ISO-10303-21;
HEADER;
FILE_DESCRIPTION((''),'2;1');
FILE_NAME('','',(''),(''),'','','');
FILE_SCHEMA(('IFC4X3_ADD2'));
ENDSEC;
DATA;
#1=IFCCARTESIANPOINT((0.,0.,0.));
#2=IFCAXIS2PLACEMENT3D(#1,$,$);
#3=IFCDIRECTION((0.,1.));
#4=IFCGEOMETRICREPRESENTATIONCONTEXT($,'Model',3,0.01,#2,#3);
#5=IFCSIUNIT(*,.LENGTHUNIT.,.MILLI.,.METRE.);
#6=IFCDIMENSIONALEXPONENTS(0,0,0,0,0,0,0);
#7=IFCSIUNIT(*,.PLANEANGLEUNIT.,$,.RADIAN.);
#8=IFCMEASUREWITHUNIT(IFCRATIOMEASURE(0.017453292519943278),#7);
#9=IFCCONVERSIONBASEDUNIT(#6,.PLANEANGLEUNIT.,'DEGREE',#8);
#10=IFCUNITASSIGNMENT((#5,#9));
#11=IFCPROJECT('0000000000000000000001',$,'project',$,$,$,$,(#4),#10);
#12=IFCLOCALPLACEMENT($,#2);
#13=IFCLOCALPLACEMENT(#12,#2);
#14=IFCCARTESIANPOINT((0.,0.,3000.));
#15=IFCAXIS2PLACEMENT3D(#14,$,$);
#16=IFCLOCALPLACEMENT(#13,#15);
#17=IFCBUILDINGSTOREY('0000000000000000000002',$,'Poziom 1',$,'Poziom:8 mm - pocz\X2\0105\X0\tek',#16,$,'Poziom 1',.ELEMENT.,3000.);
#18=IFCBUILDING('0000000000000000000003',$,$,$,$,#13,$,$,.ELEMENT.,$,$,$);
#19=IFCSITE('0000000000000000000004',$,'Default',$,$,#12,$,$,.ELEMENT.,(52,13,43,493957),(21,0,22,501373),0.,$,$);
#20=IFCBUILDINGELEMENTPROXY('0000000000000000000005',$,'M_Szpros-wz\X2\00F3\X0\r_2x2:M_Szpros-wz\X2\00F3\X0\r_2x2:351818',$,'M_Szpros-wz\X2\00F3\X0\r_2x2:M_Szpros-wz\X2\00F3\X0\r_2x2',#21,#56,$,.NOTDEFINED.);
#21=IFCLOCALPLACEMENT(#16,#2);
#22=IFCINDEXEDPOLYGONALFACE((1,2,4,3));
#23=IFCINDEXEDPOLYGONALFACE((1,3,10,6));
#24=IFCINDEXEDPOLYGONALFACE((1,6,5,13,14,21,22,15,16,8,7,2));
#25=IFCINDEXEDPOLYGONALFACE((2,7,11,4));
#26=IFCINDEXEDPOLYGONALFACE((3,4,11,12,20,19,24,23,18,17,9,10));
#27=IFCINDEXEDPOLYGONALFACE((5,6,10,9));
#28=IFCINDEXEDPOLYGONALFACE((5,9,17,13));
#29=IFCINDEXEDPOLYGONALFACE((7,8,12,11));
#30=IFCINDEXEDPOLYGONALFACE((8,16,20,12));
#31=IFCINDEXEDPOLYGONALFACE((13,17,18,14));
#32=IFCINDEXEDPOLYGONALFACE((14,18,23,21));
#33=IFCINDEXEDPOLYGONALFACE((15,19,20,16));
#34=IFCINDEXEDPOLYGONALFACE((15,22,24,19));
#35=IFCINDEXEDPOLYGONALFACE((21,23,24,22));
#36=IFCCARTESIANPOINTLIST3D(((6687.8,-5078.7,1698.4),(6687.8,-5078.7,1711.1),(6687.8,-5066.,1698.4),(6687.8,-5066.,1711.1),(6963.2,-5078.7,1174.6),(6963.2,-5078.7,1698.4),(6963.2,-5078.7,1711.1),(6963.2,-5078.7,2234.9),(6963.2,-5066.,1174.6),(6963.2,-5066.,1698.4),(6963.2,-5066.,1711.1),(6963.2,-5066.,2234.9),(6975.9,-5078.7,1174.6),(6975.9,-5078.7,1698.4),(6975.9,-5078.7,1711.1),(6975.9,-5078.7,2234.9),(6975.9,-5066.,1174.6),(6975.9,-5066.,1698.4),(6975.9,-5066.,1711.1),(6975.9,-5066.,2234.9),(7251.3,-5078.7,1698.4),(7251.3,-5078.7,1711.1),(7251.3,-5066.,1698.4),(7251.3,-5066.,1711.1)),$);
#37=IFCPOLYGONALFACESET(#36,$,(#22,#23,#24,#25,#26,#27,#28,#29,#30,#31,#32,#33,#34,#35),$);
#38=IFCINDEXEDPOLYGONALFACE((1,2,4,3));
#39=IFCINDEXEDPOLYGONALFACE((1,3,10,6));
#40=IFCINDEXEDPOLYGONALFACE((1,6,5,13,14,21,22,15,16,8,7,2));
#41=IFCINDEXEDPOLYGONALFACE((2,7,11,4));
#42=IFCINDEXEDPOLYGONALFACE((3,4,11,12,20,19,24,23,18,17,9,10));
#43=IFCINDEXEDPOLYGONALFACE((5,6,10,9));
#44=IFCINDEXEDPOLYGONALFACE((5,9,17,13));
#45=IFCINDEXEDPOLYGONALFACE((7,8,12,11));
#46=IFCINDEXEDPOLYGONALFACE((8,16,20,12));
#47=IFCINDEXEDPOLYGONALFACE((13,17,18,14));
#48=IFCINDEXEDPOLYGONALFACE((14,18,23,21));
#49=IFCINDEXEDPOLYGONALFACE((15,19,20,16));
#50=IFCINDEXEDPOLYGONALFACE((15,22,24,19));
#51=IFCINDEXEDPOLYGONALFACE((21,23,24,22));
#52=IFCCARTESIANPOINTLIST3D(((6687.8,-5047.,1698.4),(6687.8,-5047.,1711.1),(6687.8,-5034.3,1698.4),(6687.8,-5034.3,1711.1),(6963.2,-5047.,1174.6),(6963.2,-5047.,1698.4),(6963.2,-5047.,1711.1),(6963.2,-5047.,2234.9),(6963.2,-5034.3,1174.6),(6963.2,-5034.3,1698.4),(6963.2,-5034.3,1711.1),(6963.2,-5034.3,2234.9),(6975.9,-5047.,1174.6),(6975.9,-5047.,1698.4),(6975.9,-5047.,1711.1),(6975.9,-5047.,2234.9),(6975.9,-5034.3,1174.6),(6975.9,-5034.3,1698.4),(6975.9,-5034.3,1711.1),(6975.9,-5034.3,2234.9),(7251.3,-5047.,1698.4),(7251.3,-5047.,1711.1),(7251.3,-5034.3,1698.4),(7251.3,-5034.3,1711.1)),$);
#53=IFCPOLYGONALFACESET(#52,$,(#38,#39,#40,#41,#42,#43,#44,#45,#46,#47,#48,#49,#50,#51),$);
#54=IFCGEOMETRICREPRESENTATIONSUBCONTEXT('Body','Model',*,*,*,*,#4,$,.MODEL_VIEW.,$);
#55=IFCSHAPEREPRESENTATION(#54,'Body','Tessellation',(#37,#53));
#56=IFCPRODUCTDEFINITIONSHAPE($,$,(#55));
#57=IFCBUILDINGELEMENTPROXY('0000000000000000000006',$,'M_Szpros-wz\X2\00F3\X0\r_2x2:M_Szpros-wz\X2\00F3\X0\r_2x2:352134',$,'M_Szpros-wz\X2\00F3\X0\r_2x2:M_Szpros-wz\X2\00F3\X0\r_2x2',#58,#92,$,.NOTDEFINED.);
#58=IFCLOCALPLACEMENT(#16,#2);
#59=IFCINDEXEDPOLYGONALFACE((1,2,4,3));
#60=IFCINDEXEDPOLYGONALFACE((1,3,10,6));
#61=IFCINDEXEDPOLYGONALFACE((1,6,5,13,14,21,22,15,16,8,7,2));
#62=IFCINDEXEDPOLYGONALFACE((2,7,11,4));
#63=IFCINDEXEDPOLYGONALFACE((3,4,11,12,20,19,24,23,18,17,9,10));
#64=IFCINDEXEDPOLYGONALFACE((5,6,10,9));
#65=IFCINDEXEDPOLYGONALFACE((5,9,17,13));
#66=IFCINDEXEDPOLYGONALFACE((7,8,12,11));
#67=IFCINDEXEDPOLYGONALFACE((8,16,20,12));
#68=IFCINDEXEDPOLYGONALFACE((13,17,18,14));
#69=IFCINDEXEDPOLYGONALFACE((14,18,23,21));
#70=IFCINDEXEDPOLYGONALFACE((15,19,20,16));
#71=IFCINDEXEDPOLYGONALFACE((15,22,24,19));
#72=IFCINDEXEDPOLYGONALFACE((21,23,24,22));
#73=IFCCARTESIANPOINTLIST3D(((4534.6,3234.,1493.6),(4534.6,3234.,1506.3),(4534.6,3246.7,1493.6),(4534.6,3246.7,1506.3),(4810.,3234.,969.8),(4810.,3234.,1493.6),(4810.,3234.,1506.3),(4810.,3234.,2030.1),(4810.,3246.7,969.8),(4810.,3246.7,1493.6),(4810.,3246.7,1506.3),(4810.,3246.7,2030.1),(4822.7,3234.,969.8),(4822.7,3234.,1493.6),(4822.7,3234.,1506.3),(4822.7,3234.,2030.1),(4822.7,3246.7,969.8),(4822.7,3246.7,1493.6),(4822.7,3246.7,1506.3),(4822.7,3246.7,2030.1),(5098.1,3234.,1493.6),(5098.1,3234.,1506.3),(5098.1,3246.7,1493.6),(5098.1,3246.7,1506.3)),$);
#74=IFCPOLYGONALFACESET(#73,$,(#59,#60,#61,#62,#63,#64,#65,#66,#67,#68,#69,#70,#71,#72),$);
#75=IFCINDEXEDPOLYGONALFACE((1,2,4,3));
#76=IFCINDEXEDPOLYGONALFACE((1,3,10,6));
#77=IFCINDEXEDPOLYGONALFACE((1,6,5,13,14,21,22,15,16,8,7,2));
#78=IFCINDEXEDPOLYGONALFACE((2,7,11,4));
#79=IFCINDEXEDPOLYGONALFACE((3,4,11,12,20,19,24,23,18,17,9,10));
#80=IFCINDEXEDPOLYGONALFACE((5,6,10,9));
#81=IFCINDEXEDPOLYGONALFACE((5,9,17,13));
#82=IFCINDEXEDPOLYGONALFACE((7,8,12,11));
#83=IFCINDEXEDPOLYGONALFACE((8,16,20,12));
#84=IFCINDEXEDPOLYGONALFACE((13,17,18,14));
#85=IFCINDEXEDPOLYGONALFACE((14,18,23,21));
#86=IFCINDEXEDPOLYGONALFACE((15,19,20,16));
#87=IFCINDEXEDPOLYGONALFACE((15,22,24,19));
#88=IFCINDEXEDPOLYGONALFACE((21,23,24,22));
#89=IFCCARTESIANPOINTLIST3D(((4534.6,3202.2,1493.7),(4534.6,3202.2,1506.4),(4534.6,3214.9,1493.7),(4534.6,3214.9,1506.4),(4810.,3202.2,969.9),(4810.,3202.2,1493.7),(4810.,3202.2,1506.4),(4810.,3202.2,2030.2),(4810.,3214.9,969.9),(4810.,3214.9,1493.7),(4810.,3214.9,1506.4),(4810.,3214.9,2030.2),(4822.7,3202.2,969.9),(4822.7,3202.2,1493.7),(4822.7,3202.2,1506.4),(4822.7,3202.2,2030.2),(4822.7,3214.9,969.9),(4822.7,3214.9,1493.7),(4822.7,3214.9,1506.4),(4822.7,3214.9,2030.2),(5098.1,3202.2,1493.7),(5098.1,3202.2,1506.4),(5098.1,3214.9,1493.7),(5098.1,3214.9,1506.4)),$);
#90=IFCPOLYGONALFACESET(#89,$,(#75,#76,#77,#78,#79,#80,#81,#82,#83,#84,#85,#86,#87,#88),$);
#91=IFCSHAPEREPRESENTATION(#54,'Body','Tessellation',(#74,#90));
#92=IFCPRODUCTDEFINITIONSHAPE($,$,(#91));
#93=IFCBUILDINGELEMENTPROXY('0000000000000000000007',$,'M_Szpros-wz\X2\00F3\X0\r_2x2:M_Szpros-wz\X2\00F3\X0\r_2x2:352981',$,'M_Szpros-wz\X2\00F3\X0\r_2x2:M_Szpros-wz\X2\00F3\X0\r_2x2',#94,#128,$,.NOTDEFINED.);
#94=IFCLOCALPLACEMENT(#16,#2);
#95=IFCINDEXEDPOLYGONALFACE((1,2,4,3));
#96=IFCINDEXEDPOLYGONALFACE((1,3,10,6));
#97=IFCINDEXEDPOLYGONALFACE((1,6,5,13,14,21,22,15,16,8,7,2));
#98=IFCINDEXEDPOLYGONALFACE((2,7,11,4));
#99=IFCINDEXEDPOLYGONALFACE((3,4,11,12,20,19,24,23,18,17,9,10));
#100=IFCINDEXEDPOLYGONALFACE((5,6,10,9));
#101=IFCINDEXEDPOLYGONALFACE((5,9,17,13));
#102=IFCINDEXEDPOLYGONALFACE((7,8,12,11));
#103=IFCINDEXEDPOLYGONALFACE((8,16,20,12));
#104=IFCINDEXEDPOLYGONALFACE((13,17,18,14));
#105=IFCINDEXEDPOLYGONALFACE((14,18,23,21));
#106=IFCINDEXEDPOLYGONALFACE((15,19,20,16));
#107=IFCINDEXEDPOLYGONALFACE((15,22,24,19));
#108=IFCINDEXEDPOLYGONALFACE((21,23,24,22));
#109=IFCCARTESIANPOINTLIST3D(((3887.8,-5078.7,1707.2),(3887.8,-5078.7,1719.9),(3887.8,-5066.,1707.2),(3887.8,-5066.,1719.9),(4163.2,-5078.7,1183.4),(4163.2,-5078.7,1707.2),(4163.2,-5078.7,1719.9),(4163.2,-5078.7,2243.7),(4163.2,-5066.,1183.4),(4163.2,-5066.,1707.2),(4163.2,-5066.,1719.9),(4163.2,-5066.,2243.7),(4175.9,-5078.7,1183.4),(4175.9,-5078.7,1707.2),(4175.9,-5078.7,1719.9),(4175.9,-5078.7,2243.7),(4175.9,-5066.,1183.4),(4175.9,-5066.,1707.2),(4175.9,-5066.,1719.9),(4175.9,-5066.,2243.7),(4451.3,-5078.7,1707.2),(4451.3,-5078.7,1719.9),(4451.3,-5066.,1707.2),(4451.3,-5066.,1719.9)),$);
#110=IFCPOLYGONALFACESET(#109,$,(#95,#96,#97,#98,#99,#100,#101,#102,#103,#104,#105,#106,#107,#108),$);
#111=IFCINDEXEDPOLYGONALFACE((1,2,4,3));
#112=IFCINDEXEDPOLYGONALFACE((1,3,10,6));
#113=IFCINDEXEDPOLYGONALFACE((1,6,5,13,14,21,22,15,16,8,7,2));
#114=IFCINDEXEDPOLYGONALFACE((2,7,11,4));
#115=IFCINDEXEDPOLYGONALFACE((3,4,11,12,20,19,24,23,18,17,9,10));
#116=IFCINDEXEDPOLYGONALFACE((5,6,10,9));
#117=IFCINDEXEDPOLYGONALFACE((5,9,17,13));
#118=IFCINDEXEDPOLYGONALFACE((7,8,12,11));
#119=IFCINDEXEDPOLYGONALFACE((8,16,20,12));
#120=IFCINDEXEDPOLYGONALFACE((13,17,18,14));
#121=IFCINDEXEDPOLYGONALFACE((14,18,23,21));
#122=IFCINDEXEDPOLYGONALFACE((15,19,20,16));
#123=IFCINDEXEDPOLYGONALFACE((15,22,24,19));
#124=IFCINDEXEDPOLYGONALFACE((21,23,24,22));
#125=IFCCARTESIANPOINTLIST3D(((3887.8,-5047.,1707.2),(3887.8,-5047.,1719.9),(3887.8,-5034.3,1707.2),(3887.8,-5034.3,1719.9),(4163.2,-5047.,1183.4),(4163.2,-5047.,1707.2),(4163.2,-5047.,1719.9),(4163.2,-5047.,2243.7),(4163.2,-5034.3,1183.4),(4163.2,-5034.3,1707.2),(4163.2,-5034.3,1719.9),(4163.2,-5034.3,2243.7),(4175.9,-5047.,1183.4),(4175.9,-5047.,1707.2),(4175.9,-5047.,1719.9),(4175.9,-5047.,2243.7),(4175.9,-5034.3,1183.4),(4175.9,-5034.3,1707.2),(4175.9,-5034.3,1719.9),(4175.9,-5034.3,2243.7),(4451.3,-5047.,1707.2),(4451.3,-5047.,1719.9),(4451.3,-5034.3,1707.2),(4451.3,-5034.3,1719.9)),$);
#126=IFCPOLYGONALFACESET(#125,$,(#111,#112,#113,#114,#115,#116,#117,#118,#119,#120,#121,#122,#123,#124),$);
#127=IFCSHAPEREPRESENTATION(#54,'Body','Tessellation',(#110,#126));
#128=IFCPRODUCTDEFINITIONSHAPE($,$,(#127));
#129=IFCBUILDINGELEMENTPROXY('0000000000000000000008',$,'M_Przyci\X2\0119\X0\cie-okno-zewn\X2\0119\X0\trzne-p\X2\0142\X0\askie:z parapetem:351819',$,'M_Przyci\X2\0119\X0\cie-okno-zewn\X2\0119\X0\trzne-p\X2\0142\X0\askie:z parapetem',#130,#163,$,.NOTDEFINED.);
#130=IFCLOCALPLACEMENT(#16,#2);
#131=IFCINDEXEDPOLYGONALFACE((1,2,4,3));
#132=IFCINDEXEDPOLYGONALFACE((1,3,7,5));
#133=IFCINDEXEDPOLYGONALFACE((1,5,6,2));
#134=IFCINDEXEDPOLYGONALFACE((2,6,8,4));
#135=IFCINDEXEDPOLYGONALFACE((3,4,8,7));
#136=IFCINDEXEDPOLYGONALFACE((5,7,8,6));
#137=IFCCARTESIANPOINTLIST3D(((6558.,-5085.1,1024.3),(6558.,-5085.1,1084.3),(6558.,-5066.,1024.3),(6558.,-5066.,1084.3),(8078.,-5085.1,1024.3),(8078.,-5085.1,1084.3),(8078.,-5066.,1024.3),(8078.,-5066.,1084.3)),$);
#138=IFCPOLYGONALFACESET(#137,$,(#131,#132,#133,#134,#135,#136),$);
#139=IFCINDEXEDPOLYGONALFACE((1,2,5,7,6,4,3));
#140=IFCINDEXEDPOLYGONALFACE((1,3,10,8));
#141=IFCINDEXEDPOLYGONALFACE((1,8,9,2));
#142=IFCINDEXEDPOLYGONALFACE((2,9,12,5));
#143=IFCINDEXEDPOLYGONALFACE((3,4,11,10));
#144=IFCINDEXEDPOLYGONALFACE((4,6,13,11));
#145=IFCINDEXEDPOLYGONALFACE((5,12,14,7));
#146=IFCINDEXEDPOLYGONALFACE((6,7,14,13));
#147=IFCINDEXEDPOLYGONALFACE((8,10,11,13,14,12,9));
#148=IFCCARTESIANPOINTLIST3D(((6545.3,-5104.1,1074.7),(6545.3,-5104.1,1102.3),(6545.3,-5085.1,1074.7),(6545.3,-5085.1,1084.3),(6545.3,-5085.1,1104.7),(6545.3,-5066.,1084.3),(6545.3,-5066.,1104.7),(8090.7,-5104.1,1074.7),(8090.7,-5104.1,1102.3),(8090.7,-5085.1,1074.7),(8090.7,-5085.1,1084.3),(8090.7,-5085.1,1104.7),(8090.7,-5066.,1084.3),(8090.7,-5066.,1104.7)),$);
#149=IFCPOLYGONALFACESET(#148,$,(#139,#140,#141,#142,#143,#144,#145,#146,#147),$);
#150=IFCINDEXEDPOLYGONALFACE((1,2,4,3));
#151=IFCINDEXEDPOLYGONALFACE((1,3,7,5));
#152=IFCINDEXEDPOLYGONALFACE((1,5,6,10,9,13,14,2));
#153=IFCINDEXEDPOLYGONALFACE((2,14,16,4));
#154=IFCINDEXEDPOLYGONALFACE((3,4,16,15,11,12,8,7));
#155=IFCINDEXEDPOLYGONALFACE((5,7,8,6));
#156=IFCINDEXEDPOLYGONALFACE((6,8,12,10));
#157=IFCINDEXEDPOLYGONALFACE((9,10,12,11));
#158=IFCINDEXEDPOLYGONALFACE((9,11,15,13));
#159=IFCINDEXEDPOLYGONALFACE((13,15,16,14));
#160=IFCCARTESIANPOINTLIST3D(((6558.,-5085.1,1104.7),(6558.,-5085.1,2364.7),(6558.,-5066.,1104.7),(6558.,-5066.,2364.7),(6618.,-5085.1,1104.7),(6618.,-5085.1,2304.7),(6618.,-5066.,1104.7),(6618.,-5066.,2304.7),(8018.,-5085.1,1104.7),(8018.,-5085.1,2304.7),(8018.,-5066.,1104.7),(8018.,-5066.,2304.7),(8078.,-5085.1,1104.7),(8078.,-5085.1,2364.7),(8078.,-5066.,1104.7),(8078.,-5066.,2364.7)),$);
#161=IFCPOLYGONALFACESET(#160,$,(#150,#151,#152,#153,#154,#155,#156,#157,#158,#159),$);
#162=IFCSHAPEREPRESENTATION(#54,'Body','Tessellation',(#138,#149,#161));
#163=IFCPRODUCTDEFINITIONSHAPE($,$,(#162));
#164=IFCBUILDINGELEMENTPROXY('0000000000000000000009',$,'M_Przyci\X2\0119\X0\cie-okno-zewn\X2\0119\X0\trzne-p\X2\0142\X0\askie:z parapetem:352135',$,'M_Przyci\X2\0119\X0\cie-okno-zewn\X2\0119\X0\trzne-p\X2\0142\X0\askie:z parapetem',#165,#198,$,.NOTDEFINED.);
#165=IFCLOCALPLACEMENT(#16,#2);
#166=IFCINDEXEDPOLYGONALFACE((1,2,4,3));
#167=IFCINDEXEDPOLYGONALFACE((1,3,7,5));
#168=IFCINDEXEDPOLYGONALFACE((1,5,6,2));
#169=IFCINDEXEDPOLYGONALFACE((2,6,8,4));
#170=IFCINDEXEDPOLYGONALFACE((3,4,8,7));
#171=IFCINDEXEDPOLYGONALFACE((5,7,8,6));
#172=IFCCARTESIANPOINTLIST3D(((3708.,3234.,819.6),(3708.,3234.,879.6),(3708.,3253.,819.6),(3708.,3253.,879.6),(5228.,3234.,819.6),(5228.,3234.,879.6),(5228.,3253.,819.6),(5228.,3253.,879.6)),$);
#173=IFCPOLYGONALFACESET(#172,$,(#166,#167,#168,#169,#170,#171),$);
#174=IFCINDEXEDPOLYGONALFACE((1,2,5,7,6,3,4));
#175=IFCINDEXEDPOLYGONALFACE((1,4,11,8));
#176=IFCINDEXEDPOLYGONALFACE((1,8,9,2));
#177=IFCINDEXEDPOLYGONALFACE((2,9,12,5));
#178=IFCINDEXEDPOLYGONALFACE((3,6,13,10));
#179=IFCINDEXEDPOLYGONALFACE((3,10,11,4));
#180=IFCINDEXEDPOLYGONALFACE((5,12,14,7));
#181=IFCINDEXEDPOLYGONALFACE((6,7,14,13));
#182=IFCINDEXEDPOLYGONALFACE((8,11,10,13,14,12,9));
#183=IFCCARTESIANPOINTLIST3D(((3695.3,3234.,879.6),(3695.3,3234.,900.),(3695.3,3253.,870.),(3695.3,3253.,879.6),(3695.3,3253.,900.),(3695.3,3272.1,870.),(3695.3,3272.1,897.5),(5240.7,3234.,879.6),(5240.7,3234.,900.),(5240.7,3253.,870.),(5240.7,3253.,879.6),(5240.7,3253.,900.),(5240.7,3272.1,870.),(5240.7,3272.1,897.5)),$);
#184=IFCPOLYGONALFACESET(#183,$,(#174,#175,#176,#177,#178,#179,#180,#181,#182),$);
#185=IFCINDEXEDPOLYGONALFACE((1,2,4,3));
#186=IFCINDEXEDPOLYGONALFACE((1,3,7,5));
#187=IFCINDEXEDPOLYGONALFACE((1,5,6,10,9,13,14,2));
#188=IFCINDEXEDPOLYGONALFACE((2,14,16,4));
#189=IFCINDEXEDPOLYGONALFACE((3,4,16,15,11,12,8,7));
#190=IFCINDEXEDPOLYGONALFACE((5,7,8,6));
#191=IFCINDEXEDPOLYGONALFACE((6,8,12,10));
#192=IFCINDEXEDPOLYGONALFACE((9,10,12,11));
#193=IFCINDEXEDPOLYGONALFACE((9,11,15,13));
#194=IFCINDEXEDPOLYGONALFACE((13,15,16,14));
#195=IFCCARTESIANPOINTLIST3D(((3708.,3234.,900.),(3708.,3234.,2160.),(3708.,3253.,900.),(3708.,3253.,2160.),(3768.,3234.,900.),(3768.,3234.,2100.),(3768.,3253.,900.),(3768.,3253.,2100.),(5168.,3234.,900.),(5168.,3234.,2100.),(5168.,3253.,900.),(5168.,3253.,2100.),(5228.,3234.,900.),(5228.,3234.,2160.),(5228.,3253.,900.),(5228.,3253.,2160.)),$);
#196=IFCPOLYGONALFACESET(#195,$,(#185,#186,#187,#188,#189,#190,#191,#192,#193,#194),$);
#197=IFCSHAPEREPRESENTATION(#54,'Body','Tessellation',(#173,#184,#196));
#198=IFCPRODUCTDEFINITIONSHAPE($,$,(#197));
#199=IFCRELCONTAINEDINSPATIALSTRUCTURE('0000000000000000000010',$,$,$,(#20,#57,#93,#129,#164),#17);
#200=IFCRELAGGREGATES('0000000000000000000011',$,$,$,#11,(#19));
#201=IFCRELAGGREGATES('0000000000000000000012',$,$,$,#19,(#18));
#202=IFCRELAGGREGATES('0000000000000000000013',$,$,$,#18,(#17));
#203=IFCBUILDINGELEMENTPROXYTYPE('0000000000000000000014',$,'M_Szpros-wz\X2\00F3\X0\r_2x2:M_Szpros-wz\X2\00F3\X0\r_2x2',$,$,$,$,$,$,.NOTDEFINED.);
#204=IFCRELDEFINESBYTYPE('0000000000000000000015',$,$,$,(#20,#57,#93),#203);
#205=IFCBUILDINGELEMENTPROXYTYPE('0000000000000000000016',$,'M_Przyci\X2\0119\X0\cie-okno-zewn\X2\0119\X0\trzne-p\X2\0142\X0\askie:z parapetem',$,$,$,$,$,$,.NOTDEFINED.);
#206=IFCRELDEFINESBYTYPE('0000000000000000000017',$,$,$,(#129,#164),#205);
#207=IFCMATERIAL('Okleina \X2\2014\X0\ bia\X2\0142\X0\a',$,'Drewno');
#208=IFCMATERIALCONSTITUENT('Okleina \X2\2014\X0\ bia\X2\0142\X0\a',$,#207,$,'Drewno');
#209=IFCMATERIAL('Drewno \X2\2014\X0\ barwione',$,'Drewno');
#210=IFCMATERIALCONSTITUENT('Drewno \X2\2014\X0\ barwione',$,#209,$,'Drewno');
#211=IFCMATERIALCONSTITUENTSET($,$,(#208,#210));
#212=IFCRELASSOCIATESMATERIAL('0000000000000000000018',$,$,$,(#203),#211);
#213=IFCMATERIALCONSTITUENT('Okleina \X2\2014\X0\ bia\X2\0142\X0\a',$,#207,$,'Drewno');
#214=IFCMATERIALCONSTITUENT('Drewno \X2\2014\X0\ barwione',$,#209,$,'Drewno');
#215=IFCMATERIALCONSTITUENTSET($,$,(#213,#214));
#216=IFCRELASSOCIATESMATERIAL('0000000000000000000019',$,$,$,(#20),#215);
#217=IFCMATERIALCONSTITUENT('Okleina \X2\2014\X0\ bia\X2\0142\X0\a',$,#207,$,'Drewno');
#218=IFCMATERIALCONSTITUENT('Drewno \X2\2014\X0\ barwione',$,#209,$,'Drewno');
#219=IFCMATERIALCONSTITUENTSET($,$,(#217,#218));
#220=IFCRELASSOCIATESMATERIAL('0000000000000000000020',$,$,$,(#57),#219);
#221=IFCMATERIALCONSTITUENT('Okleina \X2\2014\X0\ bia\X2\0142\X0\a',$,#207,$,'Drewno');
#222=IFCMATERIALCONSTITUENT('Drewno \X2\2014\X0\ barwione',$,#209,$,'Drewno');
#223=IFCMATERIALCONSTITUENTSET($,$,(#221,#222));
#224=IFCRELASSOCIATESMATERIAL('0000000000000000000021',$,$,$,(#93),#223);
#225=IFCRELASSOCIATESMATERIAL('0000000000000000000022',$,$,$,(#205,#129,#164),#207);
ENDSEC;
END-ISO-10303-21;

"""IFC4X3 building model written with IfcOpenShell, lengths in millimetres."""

from ifc_helpers import new_model, entity, si_unit, converted_unit, direction, frame, frame_2d, origin, place, context, subcontext, project, spatial, polyline, rectangle, outline, extrude, source, transform, mapped, material, constituent, constituent_set, type_object, type_shapes, element, save


model = new_model("IFC4X3")

# Units and contexts
model_context = context("Model", 3, precision=0.01, world=origin(), true_north=direction((0.0, 1.0)))
body_context = subcontext(model_context, "Body", "Model", "MODEL_VIEW")
ifc_project = project(units=[si_unit("LENGTHUNIT", "METRE", prefix="MILLI"), converted_unit("PLANEANGLEUNIT", "DEGREE", entity("IfcRatioMeasure", 0.017453292519943278), si_unit("PLANEANGLEUNIT", "RADIAN"), dimensions=[0, 0, 0, 0, 0, 0, 0])], contexts=[model_context])

# Site, building, storey
site_placement = place(None, origin())
site = spatial("IfcSite", under=ifc_project, at=site_placement, Name="Default", CompositionType="ELEMENT", RefLatitude=(52, 13, 43, 493957), RefLongitude=(21, 0, 22, 501373), RefElevation=0.0)
building_placement = place(site_placement, origin())
building = spatial("IfcBuilding", under=site, at=building_placement, CompositionType="ELEMENT")
storey_placement = place(building_placement, frame((0.0, 0.0, 3000.0)))
storey = spatial("IfcBuildingStorey", under=building, at=storey_placement, Name="Poziom 1", ObjectType="Poziom:8 mm - początek", LongName="Poziom 1", CompositionType="ELEMENT", Elevation=3000.0)

# Building element proxies
ifc_material_1 = material(Name="Okleina — biała", Category="Drewno")
ifc_material_2 = material(Name="Drewno — barwione", Category="Drewno")
ifc_constituent_1 = constituent(ifc_material_1, Name="Okleina — biała", Category="Drewno")
ifc_constituent_2 = constituent(ifc_material_2, Name="Drewno — barwione", Category="Drewno")
ifc_constituent_set_1 = constituent_set(constituents=[ifc_constituent_1, ifc_constituent_2])
ifc_constituent_3 = constituent(ifc_material_1, Name="Okleina — biała", Category="Drewno")
ifc_constituent_4 = constituent(ifc_material_2, Name="Drewno — barwione", Category="Drewno")
ifc_constituent_set_2 = constituent_set(constituents=[ifc_constituent_3, ifc_constituent_4])
building_element_proxy_type_1 = type_object("IfcBuildingElementProxyType", Name="M_Szpros-wzór_2x2:M_Szpros-wzór_2x2", PredefinedType="NOTDEFINED", material=ifc_constituent_set_2)
shared_shape_1 = source(origin(), body_context, "Body", "SweptSolid", [
    extrude(outline(polyline([(6.4, -6.4), (530.1, -6.4), (530.1, 6.3), (6.4, 6.3), (6.4, 281.7), (-6.3, 281.7), (-6.3, 6.3), (-530.2, 6.3), (-530.2, -6.4), (-6.3, -6.4), (-6.3, -281.7), (6.4, -281.7), (6.4, -6.4)])), frame((0.0, -22.2, 530.1), z_axis=(0.0, 1.0, 0.0), x_axis=(0.0, 0.0, 1.0)), (0.0, 0.0, 1.0), 12.7),
    extrude(outline(polyline([(6.4, -6.4), (530.2, -6.4), (530.2, 6.3), (6.4, 6.3), (6.4, 281.7), (-6.3, 281.7), (-6.3, 6.3), (-530.2, 6.3), (-530.2, -6.4), (-6.3, -6.4), (-6.3, -281.7), (6.4, -281.7), (6.4, -6.4)])), frame((0.0, 9.5, 530.2), z_axis=(0.0, 1.0, 0.0), x_axis=(0.0, 0.0, 1.0)), (0.0, 0.0, 1.0), 12.7),
])
type_shapes(building_element_proxy_type_1, [shared_shape_1])
proxy_1_placement = place(storey_placement, frame((6969.6, -5056.5, 1174.6)))
element("IfcBuildingElementProxy", 1, at=proxy_1_placement, inside=storey, type_object=building_element_proxy_type_1, material=ifc_constituent_set_1, Name="M_Szpros-wzór_2x2:M_Szpros-wzór_2x2:351818", ObjectType="M_Szpros-wzór_2x2:M_Szpros-wzór_2x2", PredefinedType="NOTDEFINED", context=body_context, shape_type="MappedRepresentation", body=[
    mapped(shared_shape_1, transform((0.0, 0.0, 0.0), scale=1.0)),
])
ifc_constituent_5 = constituent(ifc_material_1, Name="Okleina — biała", Category="Drewno")
ifc_constituent_6 = constituent(ifc_material_2, Name="Drewno — barwione", Category="Drewno")
ifc_constituent_set_3 = constituent_set(constituents=[ifc_constituent_5, ifc_constituent_6])
proxy_2_placement = place(storey_placement, frame((4816.4, 3224.5, 969.9), z_axis=(0.0, 0.0, 1.0), x_axis=(-1.0, 0.0, 0.0)))
element("IfcBuildingElementProxy", 2, at=proxy_2_placement, inside=storey, type_object=building_element_proxy_type_1, material=ifc_constituent_set_3, Name="M_Szpros-wzór_2x2:M_Szpros-wzór_2x2:352134", ObjectType="M_Szpros-wzór_2x2:M_Szpros-wzór_2x2", PredefinedType="NOTDEFINED", context=body_context, shape_type="MappedRepresentation", body=[
    mapped(shared_shape_1, transform((0.0, 0.0, 0.0), scale=1.0)),
])
ifc_constituent_7 = constituent(ifc_material_1, Name="Okleina — biała", Category="Drewno")
ifc_constituent_8 = constituent(ifc_material_2, Name="Drewno — barwione", Category="Drewno")
ifc_constituent_set_4 = constituent_set(constituents=[ifc_constituent_7, ifc_constituent_8])
proxy_3_placement = place(storey_placement, frame((4169.6, -5056.5, 1183.4)))
element("IfcBuildingElementProxy", 3, at=proxy_3_placement, inside=storey, type_object=building_element_proxy_type_1, material=ifc_constituent_set_4, Name="M_Szpros-wzór_2x2:M_Szpros-wzór_2x2:352981", ObjectType="M_Szpros-wzór_2x2:M_Szpros-wzór_2x2", PredefinedType="NOTDEFINED", context=body_context, shape_type="MappedRepresentation", body=[
    mapped(shared_shape_1, transform((0.0, 0.0, 0.0), scale=1.0)),
])
building_element_proxy_type_2 = type_object("IfcBuildingElementProxyType", Name="M_Przycięcie-okno-zewnętrzne-płaskie:z parapetem", PredefinedType="NOTDEFINED", material=ifc_material_1)
shared_shape_2 = source(origin(), body_context, "Body", "SweptSolid", [
    extrude(rectangle(XDim=1520.0, YDim=60.0, at=frame_2d((0.0, 0.0), x_axis=(1.0, 0.0))), frame((0.0, -1250.4, 0.0), z_axis=(0.0, 0.0, 1.0), x_axis=(-1.0, 0.0, 0.0)), (0.0, 0.0, 1.0), 19.0),
    extrude(outline(polyline([(-19.0, -15.2), (0.0, -15.2), (0.0, -5.7), (19.0, -5.7), (19.0, 14.8), (0.0, 14.8), (-19.0, 12.3), (-19.0, -15.2)])), frame((-772.7, -1214.8, 19.0), z_axis=(1.0, 0.0, 0.0), x_axis=(0.0, 0.0, -1.0)), (0.0, 0.0, 1.0), 1545.4),
    extrude(outline(polyline([(-645.0, -760.0), (615.0, -760.0), (615.0, -700.0), (-585.0, -700.0), (-585.0, 700.0), (615.0, 700.0), (615.0, 760.0), (-645.0, 760.0), (-645.0, -760.0)])), frame((0.0, -585.0, 0.0), z_axis=(0.0, 0.0, 1.0), x_axis=(0.0, -1.0, 0.0)), (0.0, 0.0, 1.0), 19.0),
])
type_shapes(building_element_proxy_type_2, [shared_shape_2])
for number, where, z_axis, x_axis, name in (
    (4, (7318.0, -5066.0, 2304.7), (0.0, -1.0, 0.0), (1.0, 0.0, 0.0), "M_Przycięcie-okno-zewnętrzne-płaskie:z parapetem:351819"),
    (5, (4468.0, 3234.0, 2100.0), (0.0, 1.0, 0.0), (-1.0, 0.0, 0.0), "M_Przycięcie-okno-zewnętrzne-płaskie:z parapetem:352135"),
):
    element("IfcBuildingElementProxy", number, at=place(storey_placement, frame(where, z_axis=z_axis, x_axis=x_axis)), inside=storey, type_object=building_element_proxy_type_2, material=ifc_material_1, Name=name, ObjectType="M_Przycięcie-okno-zewnętrzne-płaskie:z parapetem", PredefinedType="NOTDEFINED", context=body_context, shape_type="MappedRepresentation", body=[
        mapped(shared_shape_2, transform((0.0, 0.0, 0.0), scale=1.0)),
    ])

save(model, "model.ifc")
